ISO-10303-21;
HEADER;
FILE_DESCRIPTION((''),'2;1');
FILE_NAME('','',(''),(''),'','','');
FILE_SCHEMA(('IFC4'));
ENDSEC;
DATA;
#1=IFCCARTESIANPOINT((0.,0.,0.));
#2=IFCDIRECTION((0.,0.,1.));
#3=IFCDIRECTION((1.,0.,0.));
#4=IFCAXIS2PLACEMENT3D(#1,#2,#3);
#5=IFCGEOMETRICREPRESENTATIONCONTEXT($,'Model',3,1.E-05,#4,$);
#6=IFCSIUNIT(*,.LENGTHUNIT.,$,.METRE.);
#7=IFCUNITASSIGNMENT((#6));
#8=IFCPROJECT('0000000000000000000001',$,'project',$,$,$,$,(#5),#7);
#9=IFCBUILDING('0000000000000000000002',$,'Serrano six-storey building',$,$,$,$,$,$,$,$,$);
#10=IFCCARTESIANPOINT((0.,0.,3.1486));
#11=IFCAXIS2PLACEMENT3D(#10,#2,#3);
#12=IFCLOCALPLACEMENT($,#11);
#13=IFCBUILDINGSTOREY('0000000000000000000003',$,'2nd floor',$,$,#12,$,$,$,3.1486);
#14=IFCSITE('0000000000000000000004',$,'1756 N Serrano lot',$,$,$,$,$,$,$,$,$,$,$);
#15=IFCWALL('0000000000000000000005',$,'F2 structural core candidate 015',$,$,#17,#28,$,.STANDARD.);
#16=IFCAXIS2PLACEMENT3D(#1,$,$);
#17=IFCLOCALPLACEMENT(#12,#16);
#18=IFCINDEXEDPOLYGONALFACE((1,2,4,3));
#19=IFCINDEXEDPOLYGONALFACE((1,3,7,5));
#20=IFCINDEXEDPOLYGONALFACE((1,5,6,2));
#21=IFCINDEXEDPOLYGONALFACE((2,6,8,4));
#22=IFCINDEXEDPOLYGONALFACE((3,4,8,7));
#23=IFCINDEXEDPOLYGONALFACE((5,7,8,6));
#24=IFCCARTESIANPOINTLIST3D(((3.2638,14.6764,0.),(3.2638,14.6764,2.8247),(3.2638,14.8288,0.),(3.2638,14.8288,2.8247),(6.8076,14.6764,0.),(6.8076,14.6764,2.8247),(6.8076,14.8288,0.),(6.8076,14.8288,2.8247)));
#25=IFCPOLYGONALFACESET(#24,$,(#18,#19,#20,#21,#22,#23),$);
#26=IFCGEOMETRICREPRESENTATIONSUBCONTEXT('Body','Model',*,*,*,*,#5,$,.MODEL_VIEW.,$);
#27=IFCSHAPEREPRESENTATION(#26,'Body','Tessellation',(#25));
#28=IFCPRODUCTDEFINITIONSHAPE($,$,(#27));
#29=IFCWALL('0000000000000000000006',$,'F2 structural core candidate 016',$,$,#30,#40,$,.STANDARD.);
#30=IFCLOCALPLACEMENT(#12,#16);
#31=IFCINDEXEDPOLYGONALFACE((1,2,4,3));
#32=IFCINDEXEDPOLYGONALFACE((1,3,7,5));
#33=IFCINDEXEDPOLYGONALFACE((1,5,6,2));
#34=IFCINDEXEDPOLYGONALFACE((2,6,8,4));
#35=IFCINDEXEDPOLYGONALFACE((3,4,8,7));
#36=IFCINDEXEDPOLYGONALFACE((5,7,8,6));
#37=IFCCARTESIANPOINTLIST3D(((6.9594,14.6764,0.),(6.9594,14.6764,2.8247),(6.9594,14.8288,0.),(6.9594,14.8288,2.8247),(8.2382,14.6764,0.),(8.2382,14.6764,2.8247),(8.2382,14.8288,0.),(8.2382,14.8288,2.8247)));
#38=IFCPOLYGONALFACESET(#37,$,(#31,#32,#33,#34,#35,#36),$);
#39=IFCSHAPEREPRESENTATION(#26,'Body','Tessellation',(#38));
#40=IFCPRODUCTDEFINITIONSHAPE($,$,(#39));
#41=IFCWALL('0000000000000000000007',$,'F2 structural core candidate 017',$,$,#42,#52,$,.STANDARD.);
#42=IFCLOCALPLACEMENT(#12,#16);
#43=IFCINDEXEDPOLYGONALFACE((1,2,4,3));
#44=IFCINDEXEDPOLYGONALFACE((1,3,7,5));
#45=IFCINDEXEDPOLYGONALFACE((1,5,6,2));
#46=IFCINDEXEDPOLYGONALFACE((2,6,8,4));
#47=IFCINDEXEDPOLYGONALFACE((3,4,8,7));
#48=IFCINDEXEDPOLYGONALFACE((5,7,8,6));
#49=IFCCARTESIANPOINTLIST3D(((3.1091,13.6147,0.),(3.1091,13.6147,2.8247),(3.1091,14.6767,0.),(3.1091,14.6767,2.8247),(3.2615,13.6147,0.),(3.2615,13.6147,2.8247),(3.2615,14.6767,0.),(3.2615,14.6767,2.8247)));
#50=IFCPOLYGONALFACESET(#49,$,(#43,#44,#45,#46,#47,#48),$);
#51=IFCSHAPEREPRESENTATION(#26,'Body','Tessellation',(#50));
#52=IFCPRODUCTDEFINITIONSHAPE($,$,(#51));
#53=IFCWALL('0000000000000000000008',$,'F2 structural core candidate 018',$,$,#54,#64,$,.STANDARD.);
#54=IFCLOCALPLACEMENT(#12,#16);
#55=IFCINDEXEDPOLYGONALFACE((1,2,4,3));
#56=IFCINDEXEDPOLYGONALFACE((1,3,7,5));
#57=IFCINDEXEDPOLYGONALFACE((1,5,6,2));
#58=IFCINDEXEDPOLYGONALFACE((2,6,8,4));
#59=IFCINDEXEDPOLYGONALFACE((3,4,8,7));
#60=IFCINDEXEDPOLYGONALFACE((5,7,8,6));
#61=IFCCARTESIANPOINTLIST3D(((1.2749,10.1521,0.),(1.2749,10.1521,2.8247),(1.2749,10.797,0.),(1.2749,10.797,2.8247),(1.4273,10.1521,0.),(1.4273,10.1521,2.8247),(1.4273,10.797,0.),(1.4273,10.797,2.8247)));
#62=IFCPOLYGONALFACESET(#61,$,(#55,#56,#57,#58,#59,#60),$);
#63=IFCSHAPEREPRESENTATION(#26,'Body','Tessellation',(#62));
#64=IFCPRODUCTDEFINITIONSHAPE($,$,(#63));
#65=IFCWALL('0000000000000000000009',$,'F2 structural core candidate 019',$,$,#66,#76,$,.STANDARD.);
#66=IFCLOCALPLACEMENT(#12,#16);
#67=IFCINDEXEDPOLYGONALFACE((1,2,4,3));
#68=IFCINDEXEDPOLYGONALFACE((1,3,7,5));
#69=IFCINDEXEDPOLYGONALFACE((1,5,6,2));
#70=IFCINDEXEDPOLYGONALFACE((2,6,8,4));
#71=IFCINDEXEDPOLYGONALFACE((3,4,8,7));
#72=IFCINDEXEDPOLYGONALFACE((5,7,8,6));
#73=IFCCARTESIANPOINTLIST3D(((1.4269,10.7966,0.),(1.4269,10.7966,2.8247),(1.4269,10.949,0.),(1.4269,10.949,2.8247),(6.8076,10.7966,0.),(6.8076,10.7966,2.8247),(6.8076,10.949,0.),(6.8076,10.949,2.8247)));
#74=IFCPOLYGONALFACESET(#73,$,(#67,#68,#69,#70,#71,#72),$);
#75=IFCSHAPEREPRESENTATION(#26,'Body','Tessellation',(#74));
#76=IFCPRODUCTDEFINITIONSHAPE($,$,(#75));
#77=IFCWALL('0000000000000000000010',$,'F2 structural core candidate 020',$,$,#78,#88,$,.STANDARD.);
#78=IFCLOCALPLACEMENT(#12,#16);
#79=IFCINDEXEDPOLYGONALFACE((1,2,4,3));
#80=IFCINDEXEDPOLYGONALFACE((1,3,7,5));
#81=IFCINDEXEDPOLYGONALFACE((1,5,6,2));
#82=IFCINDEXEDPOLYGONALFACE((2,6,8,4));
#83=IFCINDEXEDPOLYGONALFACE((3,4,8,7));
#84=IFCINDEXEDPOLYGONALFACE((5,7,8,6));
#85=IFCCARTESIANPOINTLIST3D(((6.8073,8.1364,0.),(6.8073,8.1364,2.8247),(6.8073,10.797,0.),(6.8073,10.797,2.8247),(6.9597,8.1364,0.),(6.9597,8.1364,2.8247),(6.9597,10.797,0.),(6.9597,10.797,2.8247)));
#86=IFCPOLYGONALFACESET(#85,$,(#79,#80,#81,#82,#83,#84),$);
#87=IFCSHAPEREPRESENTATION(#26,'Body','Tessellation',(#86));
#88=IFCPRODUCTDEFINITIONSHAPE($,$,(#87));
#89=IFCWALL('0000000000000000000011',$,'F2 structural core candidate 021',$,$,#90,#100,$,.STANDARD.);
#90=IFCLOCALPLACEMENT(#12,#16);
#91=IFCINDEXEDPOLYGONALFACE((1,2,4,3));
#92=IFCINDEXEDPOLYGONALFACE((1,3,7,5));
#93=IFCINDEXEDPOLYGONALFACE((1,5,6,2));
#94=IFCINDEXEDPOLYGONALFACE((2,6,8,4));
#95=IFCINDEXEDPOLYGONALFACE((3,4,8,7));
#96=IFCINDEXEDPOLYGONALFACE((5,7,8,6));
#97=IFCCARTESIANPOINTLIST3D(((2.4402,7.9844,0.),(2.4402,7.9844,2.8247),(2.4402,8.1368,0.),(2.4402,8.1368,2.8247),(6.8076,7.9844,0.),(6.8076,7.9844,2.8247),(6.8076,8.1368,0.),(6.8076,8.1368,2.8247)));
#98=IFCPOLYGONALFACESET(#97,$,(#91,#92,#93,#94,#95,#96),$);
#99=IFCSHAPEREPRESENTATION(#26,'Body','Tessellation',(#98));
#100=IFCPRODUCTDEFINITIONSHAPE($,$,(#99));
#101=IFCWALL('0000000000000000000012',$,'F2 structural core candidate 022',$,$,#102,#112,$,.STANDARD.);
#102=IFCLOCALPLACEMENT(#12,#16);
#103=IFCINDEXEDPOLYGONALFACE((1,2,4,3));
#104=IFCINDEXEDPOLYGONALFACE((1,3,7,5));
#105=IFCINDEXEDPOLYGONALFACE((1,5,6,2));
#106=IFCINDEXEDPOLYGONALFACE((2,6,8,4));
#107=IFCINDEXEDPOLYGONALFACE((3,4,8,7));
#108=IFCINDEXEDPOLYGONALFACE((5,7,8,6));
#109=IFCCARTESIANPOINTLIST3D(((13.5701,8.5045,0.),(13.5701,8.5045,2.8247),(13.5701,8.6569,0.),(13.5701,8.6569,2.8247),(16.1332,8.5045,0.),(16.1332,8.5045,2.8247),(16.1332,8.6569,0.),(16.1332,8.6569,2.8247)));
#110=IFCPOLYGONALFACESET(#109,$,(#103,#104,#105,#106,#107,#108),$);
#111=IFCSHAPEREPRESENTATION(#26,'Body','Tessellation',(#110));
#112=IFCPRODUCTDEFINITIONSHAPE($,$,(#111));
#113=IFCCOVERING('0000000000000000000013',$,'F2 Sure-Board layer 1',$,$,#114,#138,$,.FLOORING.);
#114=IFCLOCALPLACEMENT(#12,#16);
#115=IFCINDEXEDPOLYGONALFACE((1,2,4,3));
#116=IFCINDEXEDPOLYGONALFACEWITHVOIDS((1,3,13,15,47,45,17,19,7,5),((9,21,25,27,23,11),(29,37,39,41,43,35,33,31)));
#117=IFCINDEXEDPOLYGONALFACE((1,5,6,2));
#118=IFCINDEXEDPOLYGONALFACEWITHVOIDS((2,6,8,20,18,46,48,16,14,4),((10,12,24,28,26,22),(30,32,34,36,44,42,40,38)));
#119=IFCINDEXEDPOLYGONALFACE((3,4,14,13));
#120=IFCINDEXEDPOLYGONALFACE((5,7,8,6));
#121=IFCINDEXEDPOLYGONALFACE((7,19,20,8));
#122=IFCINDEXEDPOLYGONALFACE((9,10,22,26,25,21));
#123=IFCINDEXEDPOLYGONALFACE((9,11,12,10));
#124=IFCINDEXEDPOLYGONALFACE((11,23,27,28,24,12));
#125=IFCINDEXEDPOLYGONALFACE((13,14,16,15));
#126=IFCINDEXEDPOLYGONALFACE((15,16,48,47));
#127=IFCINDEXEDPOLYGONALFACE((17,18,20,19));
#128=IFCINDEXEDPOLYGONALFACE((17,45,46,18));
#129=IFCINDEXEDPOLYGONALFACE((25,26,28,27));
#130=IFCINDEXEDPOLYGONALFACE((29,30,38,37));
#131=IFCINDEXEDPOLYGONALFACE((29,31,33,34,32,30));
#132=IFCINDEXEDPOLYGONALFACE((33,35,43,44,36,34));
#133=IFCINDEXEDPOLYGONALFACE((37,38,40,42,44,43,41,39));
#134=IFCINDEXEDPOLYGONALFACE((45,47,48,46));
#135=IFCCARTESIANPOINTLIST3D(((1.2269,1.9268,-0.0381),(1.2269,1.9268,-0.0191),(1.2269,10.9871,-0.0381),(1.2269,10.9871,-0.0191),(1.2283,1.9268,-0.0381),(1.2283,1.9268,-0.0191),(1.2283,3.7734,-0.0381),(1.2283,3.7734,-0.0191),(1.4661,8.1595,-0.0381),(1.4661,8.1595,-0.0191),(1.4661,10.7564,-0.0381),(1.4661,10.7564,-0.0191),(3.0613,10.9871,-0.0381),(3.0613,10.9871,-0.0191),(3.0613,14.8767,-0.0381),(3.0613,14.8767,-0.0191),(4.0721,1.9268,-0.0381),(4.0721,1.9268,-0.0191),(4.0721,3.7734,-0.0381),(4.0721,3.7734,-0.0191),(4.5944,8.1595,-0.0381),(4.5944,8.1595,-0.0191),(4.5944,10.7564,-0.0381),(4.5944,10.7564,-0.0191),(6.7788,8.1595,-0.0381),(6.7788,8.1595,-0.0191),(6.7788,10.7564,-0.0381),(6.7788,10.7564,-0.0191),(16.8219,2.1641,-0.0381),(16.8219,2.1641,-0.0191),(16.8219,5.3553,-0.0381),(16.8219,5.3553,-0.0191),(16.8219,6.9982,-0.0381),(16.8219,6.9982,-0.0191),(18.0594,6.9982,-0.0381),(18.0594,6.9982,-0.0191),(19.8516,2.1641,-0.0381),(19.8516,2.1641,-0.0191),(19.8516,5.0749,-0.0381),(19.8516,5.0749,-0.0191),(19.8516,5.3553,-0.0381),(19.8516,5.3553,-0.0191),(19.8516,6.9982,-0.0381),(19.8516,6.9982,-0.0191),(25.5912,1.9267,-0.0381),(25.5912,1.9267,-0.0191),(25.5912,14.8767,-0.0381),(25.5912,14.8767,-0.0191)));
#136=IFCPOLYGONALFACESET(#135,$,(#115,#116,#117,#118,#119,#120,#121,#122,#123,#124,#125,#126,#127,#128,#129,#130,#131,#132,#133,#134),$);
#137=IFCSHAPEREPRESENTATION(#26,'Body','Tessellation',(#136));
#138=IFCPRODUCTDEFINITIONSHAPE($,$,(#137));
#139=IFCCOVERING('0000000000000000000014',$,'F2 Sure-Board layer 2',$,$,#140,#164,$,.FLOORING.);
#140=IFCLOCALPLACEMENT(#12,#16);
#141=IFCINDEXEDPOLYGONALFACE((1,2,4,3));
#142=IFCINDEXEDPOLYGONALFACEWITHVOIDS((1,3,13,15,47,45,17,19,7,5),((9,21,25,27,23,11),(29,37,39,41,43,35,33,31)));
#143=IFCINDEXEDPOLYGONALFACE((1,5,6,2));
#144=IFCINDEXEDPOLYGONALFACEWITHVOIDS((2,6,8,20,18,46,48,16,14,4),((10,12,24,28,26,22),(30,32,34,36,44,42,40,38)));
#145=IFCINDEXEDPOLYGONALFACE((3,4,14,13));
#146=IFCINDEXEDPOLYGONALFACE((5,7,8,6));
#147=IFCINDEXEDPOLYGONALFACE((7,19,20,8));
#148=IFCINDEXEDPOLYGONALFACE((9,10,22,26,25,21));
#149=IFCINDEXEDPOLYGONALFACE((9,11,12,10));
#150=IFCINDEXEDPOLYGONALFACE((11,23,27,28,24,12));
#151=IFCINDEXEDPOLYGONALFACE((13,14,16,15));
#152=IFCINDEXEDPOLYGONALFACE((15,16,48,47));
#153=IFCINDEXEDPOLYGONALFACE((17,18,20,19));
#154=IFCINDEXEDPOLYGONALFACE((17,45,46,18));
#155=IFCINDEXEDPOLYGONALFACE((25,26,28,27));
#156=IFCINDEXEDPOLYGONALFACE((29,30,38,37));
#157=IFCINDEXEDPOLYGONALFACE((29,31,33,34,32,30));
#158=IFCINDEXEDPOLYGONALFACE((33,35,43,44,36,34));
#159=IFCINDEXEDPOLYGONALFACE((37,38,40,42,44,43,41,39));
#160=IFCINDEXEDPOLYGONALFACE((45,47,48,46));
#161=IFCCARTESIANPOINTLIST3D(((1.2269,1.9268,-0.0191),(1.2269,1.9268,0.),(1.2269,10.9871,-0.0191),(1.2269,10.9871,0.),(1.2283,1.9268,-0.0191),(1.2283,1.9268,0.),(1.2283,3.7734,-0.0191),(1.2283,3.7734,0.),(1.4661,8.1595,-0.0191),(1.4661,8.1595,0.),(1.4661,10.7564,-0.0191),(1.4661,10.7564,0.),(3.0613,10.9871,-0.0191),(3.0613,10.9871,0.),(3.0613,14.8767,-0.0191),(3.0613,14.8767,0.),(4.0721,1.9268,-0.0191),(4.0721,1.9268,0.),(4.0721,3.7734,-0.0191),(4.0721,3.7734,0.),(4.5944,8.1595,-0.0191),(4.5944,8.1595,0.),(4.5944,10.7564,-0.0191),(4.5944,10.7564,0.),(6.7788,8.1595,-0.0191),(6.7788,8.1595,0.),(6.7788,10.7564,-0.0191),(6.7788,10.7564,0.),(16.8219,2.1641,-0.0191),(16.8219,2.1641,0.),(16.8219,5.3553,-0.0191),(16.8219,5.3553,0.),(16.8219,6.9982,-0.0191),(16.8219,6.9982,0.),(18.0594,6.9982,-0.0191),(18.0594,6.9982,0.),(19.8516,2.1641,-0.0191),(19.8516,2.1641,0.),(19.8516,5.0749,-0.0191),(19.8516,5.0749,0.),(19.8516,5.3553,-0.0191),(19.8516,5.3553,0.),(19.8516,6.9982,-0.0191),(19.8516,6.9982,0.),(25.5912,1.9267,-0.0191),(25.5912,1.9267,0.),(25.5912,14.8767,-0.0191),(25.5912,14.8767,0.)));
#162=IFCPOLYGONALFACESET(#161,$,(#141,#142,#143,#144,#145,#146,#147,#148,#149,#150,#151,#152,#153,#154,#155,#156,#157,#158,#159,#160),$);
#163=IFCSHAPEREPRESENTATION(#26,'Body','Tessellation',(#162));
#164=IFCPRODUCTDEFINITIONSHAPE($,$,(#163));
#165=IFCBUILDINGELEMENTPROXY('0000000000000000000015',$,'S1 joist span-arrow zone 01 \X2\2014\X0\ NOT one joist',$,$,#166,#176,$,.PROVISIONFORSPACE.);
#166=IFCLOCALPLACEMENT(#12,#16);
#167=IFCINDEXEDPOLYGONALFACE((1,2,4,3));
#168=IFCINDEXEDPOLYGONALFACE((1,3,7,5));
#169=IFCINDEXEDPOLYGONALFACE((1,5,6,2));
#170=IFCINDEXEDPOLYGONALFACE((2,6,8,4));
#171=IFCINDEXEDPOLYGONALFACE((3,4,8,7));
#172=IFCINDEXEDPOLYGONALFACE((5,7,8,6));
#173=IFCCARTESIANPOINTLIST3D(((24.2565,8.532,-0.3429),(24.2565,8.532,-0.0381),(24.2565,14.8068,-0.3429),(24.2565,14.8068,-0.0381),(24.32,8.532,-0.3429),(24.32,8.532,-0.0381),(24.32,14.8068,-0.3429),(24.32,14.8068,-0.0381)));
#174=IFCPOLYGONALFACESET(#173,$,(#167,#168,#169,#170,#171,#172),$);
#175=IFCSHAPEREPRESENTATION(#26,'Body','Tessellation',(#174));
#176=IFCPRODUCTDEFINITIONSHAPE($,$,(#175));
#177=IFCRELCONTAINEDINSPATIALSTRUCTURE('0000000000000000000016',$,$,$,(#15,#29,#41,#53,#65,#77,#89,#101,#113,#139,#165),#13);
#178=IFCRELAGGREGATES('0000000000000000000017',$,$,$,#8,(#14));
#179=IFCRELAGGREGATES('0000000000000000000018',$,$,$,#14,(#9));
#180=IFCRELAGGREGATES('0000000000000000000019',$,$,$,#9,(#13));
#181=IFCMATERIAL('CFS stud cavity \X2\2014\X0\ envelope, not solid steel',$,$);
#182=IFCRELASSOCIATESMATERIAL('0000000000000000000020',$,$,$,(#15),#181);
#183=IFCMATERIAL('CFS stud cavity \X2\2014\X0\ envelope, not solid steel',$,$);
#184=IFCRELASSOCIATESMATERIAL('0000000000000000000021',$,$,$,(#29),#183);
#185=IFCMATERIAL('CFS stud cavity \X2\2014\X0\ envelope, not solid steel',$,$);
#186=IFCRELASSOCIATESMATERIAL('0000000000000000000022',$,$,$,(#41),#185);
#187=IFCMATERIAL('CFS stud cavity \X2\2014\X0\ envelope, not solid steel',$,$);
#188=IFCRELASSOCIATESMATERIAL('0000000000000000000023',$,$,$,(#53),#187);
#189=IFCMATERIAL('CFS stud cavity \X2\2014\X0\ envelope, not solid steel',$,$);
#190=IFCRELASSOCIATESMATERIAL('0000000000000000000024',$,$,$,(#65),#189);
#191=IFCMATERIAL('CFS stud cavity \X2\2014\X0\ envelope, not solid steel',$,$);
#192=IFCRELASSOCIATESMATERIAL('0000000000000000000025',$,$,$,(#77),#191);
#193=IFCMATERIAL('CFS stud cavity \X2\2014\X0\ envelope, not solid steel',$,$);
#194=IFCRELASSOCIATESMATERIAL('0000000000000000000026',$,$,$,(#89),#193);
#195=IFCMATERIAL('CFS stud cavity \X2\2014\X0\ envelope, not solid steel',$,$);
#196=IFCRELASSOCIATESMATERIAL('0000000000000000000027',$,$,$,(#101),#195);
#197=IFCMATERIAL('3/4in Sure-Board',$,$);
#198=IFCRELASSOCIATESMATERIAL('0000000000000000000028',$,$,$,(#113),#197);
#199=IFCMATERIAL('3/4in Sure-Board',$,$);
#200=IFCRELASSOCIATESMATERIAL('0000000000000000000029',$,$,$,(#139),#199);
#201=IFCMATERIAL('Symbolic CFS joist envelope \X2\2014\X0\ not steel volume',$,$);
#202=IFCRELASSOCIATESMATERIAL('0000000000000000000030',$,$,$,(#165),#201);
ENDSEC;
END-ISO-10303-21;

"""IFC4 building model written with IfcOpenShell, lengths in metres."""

from ifc_helpers import new_model, si_unit, frame, origin_with_axes, place, context, subcontext, project, spatial, polyline, outline, extrude, material, element, save


model = new_model("IFC4")

# Units and contexts
model_context = context("Model", 3, precision=1e-05, world=origin_with_axes())
body_context = subcontext(model_context, "Body", "Model", "MODEL_VIEW")
ifc_project = project(units=[si_unit("LENGTHUNIT", "METRE")], contexts=[model_context])

# Site, building, storey
site = spatial("IfcSite", under=ifc_project, Name="1756 N Serrano lot")
building = spatial("IfcBuilding", under=site, Name="Serrano six-storey building")
storey_placement = place(None, frame((0.0, 0.0, 3.1486), z_axis=(0.0, 0.0, 1.0), x_axis=(1.0, 0.0, 0.0)))
storey = spatial("IfcBuildingStorey", under=building, at=storey_placement, Name="2nd floor", Elevation=3.1486)

# Walls
ifc_material_1 = material(Name="CFS stud cavity — envelope, not solid steel")
wall_1_placement = place(storey_placement, frame((0.0, 0.0, -3.1486), z_axis=(0.0, 0.0, 1.0), x_axis=(1.0, 0.0, 0.0)))
element("IfcWall", 1, at=wall_1_placement, inside=storey, material=ifc_material_1, Name="F2 structural core candidate 015", PredefinedType="STANDARD", context=body_context, shape_type="SweptSolid", body=[
    extrude(outline(polyline([(6.8076, 14.8288), (6.8076, 14.6764), (3.2638, 14.6764), (3.2638, 14.8288), (6.8076, 14.8288)])), frame((0.0, 0.0, 3.1486)), (0.0, 0.0, 1.0), 2.8247),
])
ifc_material_2 = material(Name="CFS stud cavity — envelope, not solid steel")
wall_2_placement = place(storey_placement, frame((0.0, 0.0, -3.1486), z_axis=(0.0, 0.0, 1.0), x_axis=(1.0, 0.0, 0.0)))
element("IfcWall", 2, at=wall_2_placement, inside=storey, material=ifc_material_2, Name="F2 structural core candidate 016", PredefinedType="STANDARD", context=body_context, shape_type="SweptSolid", body=[
    extrude(outline(polyline([(8.2382, 14.8288), (8.2382, 14.6764), (6.9594, 14.6764), (6.9594, 14.8288), (8.2382, 14.8288)])), frame((0.0, 0.0, 3.1486)), (0.0, 0.0, 1.0), 2.8247),
])
ifc_material_3 = material(Name="CFS stud cavity — envelope, not solid steel")
wall_3_placement = place(storey_placement, frame((0.0, 0.0, -3.1486), z_axis=(0.0, 0.0, 1.0), x_axis=(1.0, 0.0, 0.0)))
element("IfcWall", 3, at=wall_3_placement, inside=storey, material=ifc_material_3, Name="F2 structural core candidate 017", PredefinedType="STANDARD", context=body_context, shape_type="SweptSolid", body=[
    extrude(outline(polyline([(3.2615, 13.6147), (3.1091, 13.6147), (3.1091, 14.6767), (3.2615, 14.6767), (3.2615, 13.6147)])), frame((0.0, 0.0, 3.1486)), (0.0, 0.0, 1.0), 2.8247),
])
ifc_material_4 = material(Name="CFS stud cavity — envelope, not solid steel")
wall_4_placement = place(storey_placement, frame((0.0, 0.0, -3.1486), z_axis=(0.0, 0.0, 1.0), x_axis=(1.0, 0.0, 0.0)))
element("IfcWall", 4, at=wall_4_placement, inside=storey, material=ifc_material_4, Name="F2 structural core candidate 018", PredefinedType="STANDARD", context=body_context, shape_type="SweptSolid", body=[
    extrude(outline(polyline([(1.4273, 10.1521), (1.2749, 10.1521), (1.2749, 10.797), (1.4273, 10.797), (1.4273, 10.1521)])), frame((0.0, 0.0, 3.1486)), (0.0, 0.0, 1.0), 2.8247),
])
ifc_material_5 = material(Name="CFS stud cavity — envelope, not solid steel")
wall_5_placement = place(storey_placement, frame((0.0, 0.0, -3.1486), z_axis=(0.0, 0.0, 1.0), x_axis=(1.0, 0.0, 0.0)))
element("IfcWall", 5, at=wall_5_placement, inside=storey, material=ifc_material_5, Name="F2 structural core candidate 019", PredefinedType="STANDARD", context=body_context, shape_type="SweptSolid", body=[
    extrude(outline(polyline([(6.8076, 10.949), (6.8076, 10.7966), (1.4269, 10.7966), (1.4269, 10.949), (6.8076, 10.949)])), frame((0.0, 0.0, 3.1486)), (0.0, 0.0, 1.0), 2.8247),
])
ifc_material_6 = material(Name="CFS stud cavity — envelope, not solid steel")
wall_6_placement = place(storey_placement, frame((0.0, 0.0, -3.1486), z_axis=(0.0, 0.0, 1.0), x_axis=(1.0, 0.0, 0.0)))
element("IfcWall", 6, at=wall_6_placement, inside=storey, material=ifc_material_6, Name="F2 structural core candidate 020", PredefinedType="STANDARD", context=body_context, shape_type="SweptSolid", body=[
    extrude(outline(polyline([(6.9597, 8.1364), (6.8073, 8.1364), (6.8073, 10.797), (6.9597, 10.797), (6.9597, 8.1364)])), frame((0.0, 0.0, 3.1486)), (0.0, 0.0, 1.0), 2.8247),
])
ifc_material_7 = material(Name="CFS stud cavity — envelope, not solid steel")
wall_7_placement = place(storey_placement, frame((0.0, 0.0, -3.1486), z_axis=(0.0, 0.0, 1.0), x_axis=(1.0, 0.0, 0.0)))
element("IfcWall", 7, at=wall_7_placement, inside=storey, material=ifc_material_7, Name="F2 structural core candidate 021", PredefinedType="STANDARD", context=body_context, shape_type="SweptSolid", body=[
    extrude(outline(polyline([(6.8076, 8.1368), (6.8076, 7.9844), (2.4402, 7.9844), (2.4402, 8.1368), (6.8076, 8.1368)])), frame((0.0, 0.0, 3.1486)), (0.0, 0.0, 1.0), 2.8247),
])
ifc_material_8 = material(Name="CFS stud cavity — envelope, not solid steel")
wall_8_placement = place(storey_placement, frame((0.0, 0.0, -3.1486), z_axis=(0.0, 0.0, 1.0), x_axis=(1.0, 0.0, 0.0)))
element("IfcWall", 8, at=wall_8_placement, inside=storey, material=ifc_material_8, Name="F2 structural core candidate 022", PredefinedType="STANDARD", context=body_context, shape_type="SweptSolid", body=[
    extrude(outline(polyline([(16.1332, 8.6569), (16.1332, 8.5045), (13.5701, 8.5045), (13.5701, 8.6569), (16.1332, 8.6569)])), frame((0.0, 0.0, 3.1486)), (0.0, 0.0, 1.0), 2.8247),
])

# Coverings
ifc_material_9 = material(Name="3/4in Sure-Board")
covering_1_placement = place(storey_placement, frame((0.0, 0.0, -3.1486), z_axis=(0.0, 0.0, 1.0), x_axis=(1.0, 0.0, 0.0)))
element("IfcCovering", 9, at=covering_1_placement, inside=storey, material=ifc_material_9, Name="F2 Sure-Board layer 1", PredefinedType="FLOORING", context=body_context, shape_type="SweptSolid", body=[
    extrude(outline(polyline([(3.0613, 14.8767), (25.5912, 14.8767), (25.5912, 1.9267), (4.0721, 1.9268), (4.0721, 3.7734), (1.2283, 3.7734), (1.2283, 1.9268), (1.2269, 1.9268), (1.2269, 10.9871), (3.0613, 10.9871), (3.0613, 14.8767)]), holes=[polyline([(6.7788, 10.7564), (4.5944, 10.7564), (1.4661, 10.7564), (1.4661, 8.1595), (4.5944, 8.1595), (6.7788, 8.1595), (6.7788, 10.7564)]), polyline([(16.8219, 5.3553), (16.8219, 2.1641), (19.8516, 2.1641), (19.8516, 5.0749), (19.8516, 5.3553), (19.8516, 6.9982), (18.0594, 6.9982), (16.8219, 6.9982), (16.8219, 5.3553)])]), frame((0.0, 0.0, 3.1105)), (0.0, 0.0, 1.0), 0.0191),
])
ifc_material_10 = material(Name="3/4in Sure-Board")
covering_2_placement = place(storey_placement, frame((0.0, 0.0, -3.1486), z_axis=(0.0, 0.0, 1.0), x_axis=(1.0, 0.0, 0.0)))
element("IfcCovering", 10, at=covering_2_placement, inside=storey, material=ifc_material_10, Name="F2 Sure-Board layer 2", PredefinedType="FLOORING", context=body_context, shape_type="SweptSolid", body=[
    extrude(outline(polyline([(3.0613, 14.8767), (25.5912, 14.8767), (25.5912, 1.9267), (4.0721, 1.9268), (4.0721, 3.7734), (1.2283, 3.7734), (1.2283, 1.9268), (1.2269, 1.9268), (1.2269, 10.9871), (3.0613, 10.9871), (3.0613, 14.8767)]), holes=[polyline([(6.7788, 10.7564), (4.5944, 10.7564), (1.4661, 10.7564), (1.4661, 8.1595), (4.5944, 8.1595), (6.7788, 8.1595), (6.7788, 10.7564)]), polyline([(16.8219, 5.3553), (16.8219, 2.1641), (19.8516, 2.1641), (19.8516, 5.0749), (19.8516, 5.3553), (19.8516, 6.9982), (18.0594, 6.9982), (16.8219, 6.9982), (16.8219, 5.3553)])]), frame((0.0, 0.0, 3.1295)), (0.0, 0.0, 1.0), 0.0191),
])

# Building element proxy
ifc_material_11 = material(Name="Symbolic CFS joist envelope — not steel volume")
proxy_1_placement = place(storey_placement, frame((0.0, 0.0, -3.1486), z_axis=(0.0, 0.0, 1.0), x_axis=(1.0, 0.0, 0.0)))
element("IfcBuildingElementProxy", 11, at=proxy_1_placement, inside=storey, material=ifc_material_11, Name="S1 joist span-arrow zone 01 — NOT one joist", PredefinedType="PROVISIONFORSPACE", context=body_context, shape_type="SweptSolid", body=[
    extrude(outline(polyline([(24.2565, 14.8068), (24.32, 14.8068), (24.32, 8.532), (24.2565, 8.532), (24.2565, 14.8068)])), frame((0.0, 0.0, 2.8057)), (0.0, 0.0, 1.0), 0.3048),
])

save(model, "model.ifc")
